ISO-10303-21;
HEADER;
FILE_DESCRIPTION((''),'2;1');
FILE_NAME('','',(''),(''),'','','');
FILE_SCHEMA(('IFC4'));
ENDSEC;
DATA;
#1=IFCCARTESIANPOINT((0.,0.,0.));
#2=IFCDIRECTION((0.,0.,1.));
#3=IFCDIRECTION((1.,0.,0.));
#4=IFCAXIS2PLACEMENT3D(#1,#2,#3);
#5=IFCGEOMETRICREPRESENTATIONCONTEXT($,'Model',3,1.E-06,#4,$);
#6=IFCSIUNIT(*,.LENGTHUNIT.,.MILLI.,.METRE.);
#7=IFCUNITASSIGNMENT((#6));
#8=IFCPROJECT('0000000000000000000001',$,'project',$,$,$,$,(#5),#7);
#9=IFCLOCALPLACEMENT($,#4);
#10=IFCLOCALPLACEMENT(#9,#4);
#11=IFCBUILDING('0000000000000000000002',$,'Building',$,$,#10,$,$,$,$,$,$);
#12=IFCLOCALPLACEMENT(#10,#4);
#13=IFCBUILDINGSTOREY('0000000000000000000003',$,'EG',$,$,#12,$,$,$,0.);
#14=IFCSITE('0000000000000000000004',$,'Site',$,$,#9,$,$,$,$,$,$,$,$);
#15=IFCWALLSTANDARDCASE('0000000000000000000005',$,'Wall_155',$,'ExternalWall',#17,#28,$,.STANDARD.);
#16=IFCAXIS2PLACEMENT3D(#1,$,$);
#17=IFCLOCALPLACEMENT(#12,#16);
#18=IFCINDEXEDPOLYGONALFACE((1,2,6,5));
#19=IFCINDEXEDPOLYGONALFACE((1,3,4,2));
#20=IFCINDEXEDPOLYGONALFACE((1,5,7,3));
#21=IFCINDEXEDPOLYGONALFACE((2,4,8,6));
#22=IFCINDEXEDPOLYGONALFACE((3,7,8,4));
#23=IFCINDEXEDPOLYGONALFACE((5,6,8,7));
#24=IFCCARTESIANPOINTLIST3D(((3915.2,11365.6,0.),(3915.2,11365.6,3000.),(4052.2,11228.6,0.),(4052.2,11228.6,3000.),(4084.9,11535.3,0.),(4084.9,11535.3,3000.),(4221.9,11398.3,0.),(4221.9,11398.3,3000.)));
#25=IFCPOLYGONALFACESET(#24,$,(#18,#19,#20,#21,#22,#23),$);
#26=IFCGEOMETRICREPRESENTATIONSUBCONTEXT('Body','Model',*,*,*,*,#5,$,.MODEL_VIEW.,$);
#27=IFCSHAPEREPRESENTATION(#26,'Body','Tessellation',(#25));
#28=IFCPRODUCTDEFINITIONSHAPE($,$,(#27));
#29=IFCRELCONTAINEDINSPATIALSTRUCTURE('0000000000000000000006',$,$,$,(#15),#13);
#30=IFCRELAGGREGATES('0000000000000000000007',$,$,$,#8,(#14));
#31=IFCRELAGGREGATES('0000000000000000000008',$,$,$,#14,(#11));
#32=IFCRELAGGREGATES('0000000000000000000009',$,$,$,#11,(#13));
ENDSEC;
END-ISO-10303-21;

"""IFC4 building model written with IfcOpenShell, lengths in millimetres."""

from ifc_helpers import new_model, si_unit, frame, origin_with_axes, place, context, subcontext, project, spatial, rectangle, extrude, element, save


model = new_model("IFC4")

# Units and contexts
model_context = context("Model", 3, precision=1e-06, world=origin_with_axes())
body_context = subcontext(model_context, "Body", "Model", "MODEL_VIEW")
ifc_project = project(units=[si_unit("LENGTHUNIT", "METRE", prefix="MILLI")], contexts=[model_context])

# Site, building, storey
site_placement = place(None, origin_with_axes())
site = spatial("IfcSite", under=ifc_project, at=site_placement, Name="Site")
building_placement = place(site_placement, origin_with_axes())
building = spatial("IfcBuilding", under=site, at=building_placement, Name="Building")
storey_placement = place(building_placement, origin_with_axes())
storey = spatial("IfcBuildingStorey", under=building, at=storey_placement, Name="EG", Elevation=0.0)

# Wall
wall_1_placement = place(storey_placement, origin_with_axes())
element("IfcWallStandardCase", 1, at=wall_1_placement, inside=storey, Name="Wall_155", ObjectType="ExternalWall", PredefinedType="STANDARD", context=body_context, shape_type="SweptSolid", body=[
    extrude(rectangle(XDim=193.7, YDim=240.0), frame((4068.6, 11381.9, 0.0), z_axis=(0.0, 0.0, 1.0), x_axis=(-0.707107, 0.707107, 0.0)), (0.0, 0.0, 1.0), 3000.0),
])

save(model, "model.ifc")
